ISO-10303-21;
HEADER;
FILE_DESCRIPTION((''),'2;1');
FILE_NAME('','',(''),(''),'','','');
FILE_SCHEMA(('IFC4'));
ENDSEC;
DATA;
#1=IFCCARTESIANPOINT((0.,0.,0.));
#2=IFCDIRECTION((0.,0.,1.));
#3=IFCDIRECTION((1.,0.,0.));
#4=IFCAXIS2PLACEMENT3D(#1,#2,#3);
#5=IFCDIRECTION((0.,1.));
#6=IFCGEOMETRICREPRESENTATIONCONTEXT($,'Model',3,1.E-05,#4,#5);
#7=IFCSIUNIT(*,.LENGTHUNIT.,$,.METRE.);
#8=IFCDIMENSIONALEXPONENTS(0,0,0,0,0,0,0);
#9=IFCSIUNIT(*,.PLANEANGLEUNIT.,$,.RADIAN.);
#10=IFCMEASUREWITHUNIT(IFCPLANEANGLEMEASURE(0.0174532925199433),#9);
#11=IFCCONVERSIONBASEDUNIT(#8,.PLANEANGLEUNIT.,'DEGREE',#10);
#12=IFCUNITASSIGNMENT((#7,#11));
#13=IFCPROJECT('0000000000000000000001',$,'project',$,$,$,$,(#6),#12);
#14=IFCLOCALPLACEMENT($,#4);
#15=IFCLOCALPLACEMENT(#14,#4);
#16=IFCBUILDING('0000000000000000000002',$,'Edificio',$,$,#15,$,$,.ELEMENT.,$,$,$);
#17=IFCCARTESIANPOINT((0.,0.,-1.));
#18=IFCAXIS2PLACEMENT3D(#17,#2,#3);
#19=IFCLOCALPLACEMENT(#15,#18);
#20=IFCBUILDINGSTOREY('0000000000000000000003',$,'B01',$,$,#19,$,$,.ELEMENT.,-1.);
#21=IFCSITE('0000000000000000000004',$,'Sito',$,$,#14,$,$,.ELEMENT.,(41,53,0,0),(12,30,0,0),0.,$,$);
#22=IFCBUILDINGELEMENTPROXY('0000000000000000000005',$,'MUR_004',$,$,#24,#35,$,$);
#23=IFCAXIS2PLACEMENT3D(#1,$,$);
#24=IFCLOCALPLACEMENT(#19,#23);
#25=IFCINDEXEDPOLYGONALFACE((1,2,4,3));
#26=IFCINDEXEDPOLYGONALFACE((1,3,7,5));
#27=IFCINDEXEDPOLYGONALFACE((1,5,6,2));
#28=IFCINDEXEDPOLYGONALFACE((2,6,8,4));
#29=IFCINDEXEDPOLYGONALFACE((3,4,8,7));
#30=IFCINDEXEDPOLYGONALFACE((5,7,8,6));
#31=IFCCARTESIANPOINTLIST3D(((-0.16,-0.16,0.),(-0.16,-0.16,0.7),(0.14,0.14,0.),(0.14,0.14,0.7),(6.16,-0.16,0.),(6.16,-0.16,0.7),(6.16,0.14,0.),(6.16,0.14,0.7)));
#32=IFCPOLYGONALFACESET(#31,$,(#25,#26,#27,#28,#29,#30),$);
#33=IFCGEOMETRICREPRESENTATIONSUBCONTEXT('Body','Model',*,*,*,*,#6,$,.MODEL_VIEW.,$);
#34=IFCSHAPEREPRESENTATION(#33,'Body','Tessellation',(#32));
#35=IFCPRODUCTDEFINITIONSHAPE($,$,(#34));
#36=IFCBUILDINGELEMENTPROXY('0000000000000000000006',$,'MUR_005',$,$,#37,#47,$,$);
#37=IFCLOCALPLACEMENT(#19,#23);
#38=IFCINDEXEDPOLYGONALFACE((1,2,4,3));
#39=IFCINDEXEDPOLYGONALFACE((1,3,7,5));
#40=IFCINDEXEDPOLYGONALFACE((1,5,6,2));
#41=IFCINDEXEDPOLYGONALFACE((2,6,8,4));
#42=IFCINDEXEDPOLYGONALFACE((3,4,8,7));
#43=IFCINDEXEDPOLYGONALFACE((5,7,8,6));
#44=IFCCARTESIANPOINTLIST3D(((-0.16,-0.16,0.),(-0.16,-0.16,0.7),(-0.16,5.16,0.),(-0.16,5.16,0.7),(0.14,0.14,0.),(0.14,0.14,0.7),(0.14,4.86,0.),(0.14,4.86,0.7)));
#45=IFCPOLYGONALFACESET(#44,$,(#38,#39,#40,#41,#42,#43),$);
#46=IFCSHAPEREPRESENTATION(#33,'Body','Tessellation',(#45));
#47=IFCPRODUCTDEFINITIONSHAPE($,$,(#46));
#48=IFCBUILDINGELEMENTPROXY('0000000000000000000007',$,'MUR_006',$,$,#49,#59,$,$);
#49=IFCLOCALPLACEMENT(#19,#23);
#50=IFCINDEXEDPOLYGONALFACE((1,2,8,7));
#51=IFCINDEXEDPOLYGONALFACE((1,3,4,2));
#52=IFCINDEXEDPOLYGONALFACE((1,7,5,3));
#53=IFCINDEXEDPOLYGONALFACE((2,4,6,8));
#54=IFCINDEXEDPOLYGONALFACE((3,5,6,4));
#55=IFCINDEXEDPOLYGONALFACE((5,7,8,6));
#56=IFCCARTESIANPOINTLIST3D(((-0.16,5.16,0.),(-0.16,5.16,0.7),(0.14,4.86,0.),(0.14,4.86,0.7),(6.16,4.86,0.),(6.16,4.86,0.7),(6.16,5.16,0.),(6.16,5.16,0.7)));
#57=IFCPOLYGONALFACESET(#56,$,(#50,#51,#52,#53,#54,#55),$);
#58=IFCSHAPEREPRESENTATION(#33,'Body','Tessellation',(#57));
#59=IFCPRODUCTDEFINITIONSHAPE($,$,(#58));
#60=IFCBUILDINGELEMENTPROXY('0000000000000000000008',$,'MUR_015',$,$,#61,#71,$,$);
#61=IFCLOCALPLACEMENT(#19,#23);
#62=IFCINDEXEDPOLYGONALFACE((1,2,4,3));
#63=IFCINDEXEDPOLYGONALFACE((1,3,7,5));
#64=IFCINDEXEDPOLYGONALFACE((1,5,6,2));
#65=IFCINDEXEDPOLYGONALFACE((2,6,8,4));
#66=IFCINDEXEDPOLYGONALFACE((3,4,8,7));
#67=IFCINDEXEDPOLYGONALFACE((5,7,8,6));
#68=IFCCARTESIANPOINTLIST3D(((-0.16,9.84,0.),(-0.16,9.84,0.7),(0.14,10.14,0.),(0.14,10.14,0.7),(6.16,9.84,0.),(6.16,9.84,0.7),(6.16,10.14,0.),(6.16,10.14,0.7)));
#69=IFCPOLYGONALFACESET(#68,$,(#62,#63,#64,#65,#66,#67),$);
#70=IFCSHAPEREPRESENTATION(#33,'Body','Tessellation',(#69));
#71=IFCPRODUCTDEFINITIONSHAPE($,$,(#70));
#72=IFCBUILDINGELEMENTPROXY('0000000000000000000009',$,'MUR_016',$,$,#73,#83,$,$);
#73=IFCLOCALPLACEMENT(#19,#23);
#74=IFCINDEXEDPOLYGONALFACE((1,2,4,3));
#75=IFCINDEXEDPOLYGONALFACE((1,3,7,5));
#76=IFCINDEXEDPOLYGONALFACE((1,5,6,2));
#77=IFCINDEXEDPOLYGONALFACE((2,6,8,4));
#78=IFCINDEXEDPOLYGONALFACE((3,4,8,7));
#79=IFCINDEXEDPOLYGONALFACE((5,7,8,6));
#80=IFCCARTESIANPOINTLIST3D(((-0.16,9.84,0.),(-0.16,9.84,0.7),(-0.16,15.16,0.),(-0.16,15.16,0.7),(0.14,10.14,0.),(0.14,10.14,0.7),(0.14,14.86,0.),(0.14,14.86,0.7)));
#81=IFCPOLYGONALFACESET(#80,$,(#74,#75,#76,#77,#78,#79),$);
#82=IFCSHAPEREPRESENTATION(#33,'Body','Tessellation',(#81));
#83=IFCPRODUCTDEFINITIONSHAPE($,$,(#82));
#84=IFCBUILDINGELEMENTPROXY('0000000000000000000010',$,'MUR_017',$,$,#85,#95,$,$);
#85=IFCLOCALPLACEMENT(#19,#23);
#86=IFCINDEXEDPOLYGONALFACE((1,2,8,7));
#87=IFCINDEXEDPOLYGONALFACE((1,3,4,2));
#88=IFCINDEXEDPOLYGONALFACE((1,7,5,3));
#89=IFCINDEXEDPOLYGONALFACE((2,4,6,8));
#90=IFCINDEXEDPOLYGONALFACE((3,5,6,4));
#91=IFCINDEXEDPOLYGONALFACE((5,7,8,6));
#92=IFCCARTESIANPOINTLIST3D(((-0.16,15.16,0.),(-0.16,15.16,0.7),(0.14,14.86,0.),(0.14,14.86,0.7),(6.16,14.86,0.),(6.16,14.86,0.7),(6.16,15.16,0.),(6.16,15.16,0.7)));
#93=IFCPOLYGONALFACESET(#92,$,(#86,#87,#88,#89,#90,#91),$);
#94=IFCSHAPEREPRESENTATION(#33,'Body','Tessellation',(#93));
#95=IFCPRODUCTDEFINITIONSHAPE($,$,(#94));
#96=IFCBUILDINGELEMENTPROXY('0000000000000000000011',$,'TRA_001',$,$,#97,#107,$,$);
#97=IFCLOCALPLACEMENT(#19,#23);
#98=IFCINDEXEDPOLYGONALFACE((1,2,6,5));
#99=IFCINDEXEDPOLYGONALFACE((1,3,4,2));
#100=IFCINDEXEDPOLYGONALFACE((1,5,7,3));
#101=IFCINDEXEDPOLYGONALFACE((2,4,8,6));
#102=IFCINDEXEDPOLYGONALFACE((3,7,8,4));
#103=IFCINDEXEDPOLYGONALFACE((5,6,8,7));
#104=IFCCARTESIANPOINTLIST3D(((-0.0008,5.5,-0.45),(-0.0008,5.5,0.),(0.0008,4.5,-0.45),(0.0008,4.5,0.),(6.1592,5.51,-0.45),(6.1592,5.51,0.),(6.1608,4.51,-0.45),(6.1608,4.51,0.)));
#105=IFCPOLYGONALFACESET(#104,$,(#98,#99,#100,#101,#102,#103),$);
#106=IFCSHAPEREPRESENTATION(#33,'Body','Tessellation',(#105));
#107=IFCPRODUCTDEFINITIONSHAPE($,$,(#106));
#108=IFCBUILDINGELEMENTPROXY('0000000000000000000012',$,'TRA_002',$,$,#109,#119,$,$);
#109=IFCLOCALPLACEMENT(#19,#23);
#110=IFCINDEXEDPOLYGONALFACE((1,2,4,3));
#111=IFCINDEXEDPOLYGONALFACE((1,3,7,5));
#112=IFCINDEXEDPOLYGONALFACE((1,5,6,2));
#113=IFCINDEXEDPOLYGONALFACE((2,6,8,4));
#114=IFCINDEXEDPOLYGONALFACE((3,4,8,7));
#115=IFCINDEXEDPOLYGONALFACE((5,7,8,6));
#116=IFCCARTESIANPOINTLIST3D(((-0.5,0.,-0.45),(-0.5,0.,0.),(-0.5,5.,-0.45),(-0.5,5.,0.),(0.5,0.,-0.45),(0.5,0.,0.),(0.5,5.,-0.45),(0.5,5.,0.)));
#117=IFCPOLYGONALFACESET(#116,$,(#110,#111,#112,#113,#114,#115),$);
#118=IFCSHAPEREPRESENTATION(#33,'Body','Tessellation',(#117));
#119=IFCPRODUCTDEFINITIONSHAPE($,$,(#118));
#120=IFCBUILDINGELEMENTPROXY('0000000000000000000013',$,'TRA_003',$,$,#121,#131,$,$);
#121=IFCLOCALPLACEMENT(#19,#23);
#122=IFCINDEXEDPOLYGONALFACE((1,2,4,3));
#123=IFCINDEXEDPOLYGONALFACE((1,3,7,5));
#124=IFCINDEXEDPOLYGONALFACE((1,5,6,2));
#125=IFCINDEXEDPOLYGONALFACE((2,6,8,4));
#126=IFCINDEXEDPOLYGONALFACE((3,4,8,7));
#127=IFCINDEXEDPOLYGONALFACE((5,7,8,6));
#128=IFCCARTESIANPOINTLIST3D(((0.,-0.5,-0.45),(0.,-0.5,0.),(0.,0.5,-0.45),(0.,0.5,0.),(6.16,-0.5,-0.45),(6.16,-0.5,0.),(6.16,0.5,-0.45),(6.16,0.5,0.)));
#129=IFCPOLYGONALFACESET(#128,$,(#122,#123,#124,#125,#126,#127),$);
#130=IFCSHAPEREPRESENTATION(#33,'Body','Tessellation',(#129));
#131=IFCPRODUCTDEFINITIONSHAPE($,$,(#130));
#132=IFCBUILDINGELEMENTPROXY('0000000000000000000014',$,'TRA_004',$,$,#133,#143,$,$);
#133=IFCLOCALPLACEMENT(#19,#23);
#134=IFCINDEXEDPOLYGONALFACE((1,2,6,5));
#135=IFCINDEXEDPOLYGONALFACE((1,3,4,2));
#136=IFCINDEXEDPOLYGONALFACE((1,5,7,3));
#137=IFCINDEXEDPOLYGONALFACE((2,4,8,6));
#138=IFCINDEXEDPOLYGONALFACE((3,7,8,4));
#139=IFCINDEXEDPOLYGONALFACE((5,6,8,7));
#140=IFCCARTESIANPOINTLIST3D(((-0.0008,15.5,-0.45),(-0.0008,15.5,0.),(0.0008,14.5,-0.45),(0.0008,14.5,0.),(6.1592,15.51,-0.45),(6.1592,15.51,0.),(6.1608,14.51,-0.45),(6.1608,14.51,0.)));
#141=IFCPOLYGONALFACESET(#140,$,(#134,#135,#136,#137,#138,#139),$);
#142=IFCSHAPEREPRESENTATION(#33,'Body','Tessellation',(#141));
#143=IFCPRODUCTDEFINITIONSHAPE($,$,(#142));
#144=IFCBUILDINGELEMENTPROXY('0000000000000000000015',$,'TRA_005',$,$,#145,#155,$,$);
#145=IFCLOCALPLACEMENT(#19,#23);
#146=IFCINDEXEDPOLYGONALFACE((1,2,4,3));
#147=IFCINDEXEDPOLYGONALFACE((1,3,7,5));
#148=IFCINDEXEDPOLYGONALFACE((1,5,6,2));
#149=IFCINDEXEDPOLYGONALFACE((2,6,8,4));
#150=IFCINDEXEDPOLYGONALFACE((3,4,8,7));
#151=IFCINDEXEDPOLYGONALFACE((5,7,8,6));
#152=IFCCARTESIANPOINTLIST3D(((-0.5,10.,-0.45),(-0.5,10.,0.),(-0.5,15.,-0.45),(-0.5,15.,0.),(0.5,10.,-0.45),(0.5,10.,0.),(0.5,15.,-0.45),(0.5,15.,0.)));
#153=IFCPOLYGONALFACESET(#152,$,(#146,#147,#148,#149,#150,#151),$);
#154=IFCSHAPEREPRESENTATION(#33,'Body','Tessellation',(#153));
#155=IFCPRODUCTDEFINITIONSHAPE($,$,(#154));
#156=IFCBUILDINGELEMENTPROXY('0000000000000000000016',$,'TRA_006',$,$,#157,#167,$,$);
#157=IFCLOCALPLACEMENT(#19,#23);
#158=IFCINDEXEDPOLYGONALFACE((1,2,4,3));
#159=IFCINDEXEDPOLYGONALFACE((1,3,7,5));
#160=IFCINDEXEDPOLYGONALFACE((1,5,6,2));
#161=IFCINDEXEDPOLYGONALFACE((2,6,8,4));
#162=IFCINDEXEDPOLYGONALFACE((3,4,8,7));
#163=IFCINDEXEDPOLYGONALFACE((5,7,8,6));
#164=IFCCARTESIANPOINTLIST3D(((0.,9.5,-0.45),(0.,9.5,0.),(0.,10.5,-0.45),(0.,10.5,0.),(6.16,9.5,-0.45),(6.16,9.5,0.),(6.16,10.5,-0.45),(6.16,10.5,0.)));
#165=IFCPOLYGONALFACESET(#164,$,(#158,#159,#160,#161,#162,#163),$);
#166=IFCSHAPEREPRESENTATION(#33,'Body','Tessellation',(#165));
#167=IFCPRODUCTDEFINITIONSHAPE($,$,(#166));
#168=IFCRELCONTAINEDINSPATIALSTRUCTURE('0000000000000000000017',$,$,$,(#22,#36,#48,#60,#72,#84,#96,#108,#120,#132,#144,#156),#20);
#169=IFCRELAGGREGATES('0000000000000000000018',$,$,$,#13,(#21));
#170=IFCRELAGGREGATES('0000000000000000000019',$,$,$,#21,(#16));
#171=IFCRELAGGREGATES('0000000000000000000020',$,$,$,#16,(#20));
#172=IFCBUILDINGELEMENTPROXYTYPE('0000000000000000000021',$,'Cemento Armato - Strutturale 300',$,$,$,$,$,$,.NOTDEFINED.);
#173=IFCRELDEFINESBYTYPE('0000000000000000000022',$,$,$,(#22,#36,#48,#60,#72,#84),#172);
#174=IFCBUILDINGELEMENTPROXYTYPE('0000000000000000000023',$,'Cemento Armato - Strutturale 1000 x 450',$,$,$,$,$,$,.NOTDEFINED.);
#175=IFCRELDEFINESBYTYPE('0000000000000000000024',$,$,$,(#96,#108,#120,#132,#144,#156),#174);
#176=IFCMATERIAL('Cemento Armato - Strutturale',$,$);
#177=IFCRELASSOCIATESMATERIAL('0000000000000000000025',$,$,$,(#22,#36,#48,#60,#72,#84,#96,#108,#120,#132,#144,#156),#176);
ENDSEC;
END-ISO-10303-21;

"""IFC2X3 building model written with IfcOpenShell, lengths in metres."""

from ifc_helpers import new_model, entity, si_unit, converted_unit, direction, frame, frame_2d, origin_with_axes, place, context, subcontext, project, spatial, polyline, rectangle, outline, extrude, material, type_object, element, save


model = new_model("IFC2X3")

# Units and contexts
model_context = context("Model", 3, precision=1e-05, world=origin_with_axes(), true_north=direction((0.0, 1.0)))
body_context = subcontext(model_context, "Body", "Model", "MODEL_VIEW")
ifc_project = project(units=[si_unit("LENGTHUNIT", "METRE"), converted_unit("PLANEANGLEUNIT", "DEGREE", entity("IfcPlaneAngleMeasure", 0.0174532925199433), si_unit("PLANEANGLEUNIT", "RADIAN"), dimensions=[0, 0, 0, 0, 0, 0, 0])], contexts=[model_context])

# Site, building, storey
site_placement = place(None, origin_with_axes())
site = spatial("IfcSite", under=ifc_project, at=site_placement, Name="Sito", CompositionType="ELEMENT", RefLatitude=(41, 53, 0, 0), RefLongitude=(12, 30, 0, 0), RefElevation=0.0)
building_placement = place(site_placement, origin_with_axes())
building = spatial("IfcBuilding", under=site, at=building_placement, Name="Edificio", CompositionType="ELEMENT")
storey_placement = place(building_placement, frame((0.0, 0.0, -1.0), z_axis=(0.0, 0.0, 1.0), x_axis=(1.0, 0.0, 0.0)))
storey = spatial("IfcBuildingStorey", under=building, at=storey_placement, Name="B01", CompositionType="ELEMENT", Elevation=-1.0)

# Building element proxies
ifc_material = material(Name="Cemento Armato - Strutturale")
building_element_proxy_type_1 = type_object("IfcBuildingElementProxyType", Name="Cemento Armato - Strutturale 300", PredefinedType="NOTDEFINED")
proxy_1_placement = place(storey_placement, frame((-0.16, -0.16, 0.0), z_axis=(0.0, 0.0, 1.0), x_axis=(1.0, 0.0, 0.0)))
element("IfcBuildingElementProxy", 1, at=proxy_1_placement, inside=storey, type_object=building_element_proxy_type_1, material=ifc_material, Name="MUR_004", context=body_context, shape_type="SweptSolid", body=[
    extrude(outline(polyline([(0.0, 0.0), (6.32, 0.0), (6.32, 0.3), (0.3, 0.3), (0.0, 0.0)])), origin_with_axes(), (0.0, 0.0, 1.0), 0.7),
])
proxy_2_placement = place(storey_placement, frame((-0.16, 5.16, 0.0), z_axis=(0.0, 0.0, 1.0), x_axis=(0.0, -1.0, 0.0)))
element("IfcBuildingElementProxy", 2, at=proxy_2_placement, inside=storey, type_object=building_element_proxy_type_1, material=ifc_material, Name="MUR_005", context=body_context, shape_type="SweptSolid", body=[
    extrude(outline(polyline([(0.0, 0.0), (5.32, 0.0), (5.02, 0.3), (0.3, 0.3), (0.0, 0.0)])), origin_with_axes(), (0.0, 0.0, 1.0), 0.7),
])
proxy_3_placement = place(storey_placement, frame((6.16, 5.16, 0.0), z_axis=(0.0, 0.0, 1.0), x_axis=(-1.0, 0.0, 0.0)))
element("IfcBuildingElementProxy", 3, at=proxy_3_placement, inside=storey, type_object=building_element_proxy_type_1, material=ifc_material, Name="MUR_006", context=body_context, shape_type="SweptSolid", body=[
    extrude(outline(polyline([(0.0, 0.0), (6.32, 0.0), (6.02, 0.3), (0.0, 0.3), (0.0, 0.0)])), origin_with_axes(), (0.0, 0.0, 1.0), 0.7),
])
proxy_4_placement = place(storey_placement, frame((-0.16, 9.84, 0.0), z_axis=(0.0, 0.0, 1.0), x_axis=(1.0, 0.0, 0.0)))
element("IfcBuildingElementProxy", 4, at=proxy_4_placement, inside=storey, type_object=building_element_proxy_type_1, material=ifc_material, Name="MUR_015", context=body_context, shape_type="SweptSolid", body=[
    extrude(outline(polyline([(0.0, 0.0), (6.32, 0.0), (6.32, 0.3), (0.3, 0.3), (0.0, 0.0)])), origin_with_axes(), (0.0, 0.0, 1.0), 0.7),
])
proxy_5_placement = place(storey_placement, frame((-0.16, 15.16, 0.0), z_axis=(0.0, 0.0, 1.0), x_axis=(0.0, -1.0, 0.0)))
element("IfcBuildingElementProxy", 5, at=proxy_5_placement, inside=storey, type_object=building_element_proxy_type_1, material=ifc_material, Name="MUR_016", context=body_context, shape_type="SweptSolid", body=[
    extrude(outline(polyline([(0.0, 0.0), (5.32, 0.0), (5.02, 0.3), (0.3, 0.3), (0.0, 0.0)])), origin_with_axes(), (0.0, 0.0, 1.0), 0.7),
])
proxy_6_placement = place(storey_placement, frame((6.16, 15.16, 0.0), z_axis=(0.0, 0.0, 1.0), x_axis=(-1.0, 0.0, 0.0)))
element("IfcBuildingElementProxy", 6, at=proxy_6_placement, inside=storey, type_object=building_element_proxy_type_1, material=ifc_material, Name="MUR_017", context=body_context, shape_type="SweptSolid", body=[
    extrude(outline(polyline([(0.0, 0.0), (6.32, 0.0), (6.02, 0.3), (0.0, 0.3), (0.0, 0.0)])), origin_with_axes(), (0.0, 0.0, 1.0), 0.7),
])
building_element_proxy_type_2 = type_object("IfcBuildingElementProxyType", Name="Cemento Armato - Strutturale 1000 x 450", PredefinedType="NOTDEFINED")
proxy_7_placement = place(storey_placement, frame((6.16, 5.01, 0.0), z_axis=(0.0, 0.0, 1.0), x_axis=(-0.001623, 0.999999, 0.0)))
element("IfcBuildingElementProxy", 7, at=proxy_7_placement, inside=storey, type_object=building_element_proxy_type_2, material=ifc_material, Name="TRA_001", context=body_context, shape_type="SweptSolid", body=[
    extrude(rectangle(XDim=0.45, YDim=1.0, at=frame_2d((-0.225, 0.0), x_axis=(1.0, 0.0))), frame((0.0, 0.0, 0.0), z_axis=(0.0, 1.0, 0.0), x_axis=(0.0, 0.0, 1.0)), (0.0, 0.0, 1.0), 6.16),
])
proxy_8_placement = place(storey_placement, frame((0.0, 5.0, 0.0), z_axis=(0.0, 0.0, 1.0), x_axis=(-1.0, 0.0, 0.0)))
element("IfcBuildingElementProxy", 8, at=proxy_8_placement, inside=storey, type_object=building_element_proxy_type_2, material=ifc_material, Name="TRA_002", context=body_context, shape_type="SweptSolid", body=[
    extrude(rectangle(XDim=0.45, YDim=1.0, at=frame_2d((-0.225, 0.0), x_axis=(1.0, 0.0))), frame((0.0, 0.0, 0.0), z_axis=(0.0, 1.0, 0.0), x_axis=(0.0, 0.0, 1.0)), (0.0, 0.0, 1.0), 5.0),
])
proxy_9_placement = place(storey_placement, frame((0.0, 0.0, 0.0), z_axis=(0.0, 0.0, 1.0), x_axis=(0.0, -1.0, 0.0)))
element("IfcBuildingElementProxy", 9, at=proxy_9_placement, inside=storey, type_object=building_element_proxy_type_2, material=ifc_material, Name="TRA_003", context=body_context, shape_type="SweptSolid", body=[
    extrude(rectangle(XDim=0.45, YDim=1.0, at=frame_2d((-0.225, 0.0), x_axis=(1.0, 0.0))), frame((0.0, 0.0, 0.0), z_axis=(0.0, 1.0, 0.0), x_axis=(0.0, 0.0, 1.0)), (0.0, 0.0, 1.0), 6.16),
])
proxy_10_placement = place(storey_placement, frame((6.16, 15.01, 0.0), z_axis=(0.0, 0.0, 1.0), x_axis=(-0.001623, 0.999999, 0.0)))
element("IfcBuildingElementProxy", 10, at=proxy_10_placement, inside=storey, type_object=building_element_proxy_type_2, material=ifc_material, Name="TRA_004", context=body_context, shape_type="SweptSolid", body=[
    extrude(rectangle(XDim=0.45, YDim=1.0, at=frame_2d((-0.225, 0.0), x_axis=(1.0, 0.0))), frame((0.0, 0.0, 0.0), z_axis=(0.0, 1.0, 0.0), x_axis=(0.0, 0.0, 1.0)), (0.0, 0.0, 1.0), 6.16),
])
proxy_11_placement = place(storey_placement, frame((0.0, 15.0, 0.0), z_axis=(0.0, 0.0, 1.0), x_axis=(-1.0, 0.0, 0.0)))
element("IfcBuildingElementProxy", 11, at=proxy_11_placement, inside=storey, type_object=building_element_proxy_type_2, material=ifc_material, Name="TRA_005", context=body_context, shape_type="SweptSolid", body=[
    extrude(rectangle(XDim=0.45, YDim=1.0, at=frame_2d((-0.225, 0.0), x_axis=(1.0, 0.0))), frame((0.0, 0.0, 0.0), z_axis=(0.0, 1.0, 0.0), x_axis=(0.0, 0.0, 1.0)), (0.0, 0.0, 1.0), 5.0),
])
proxy_12_placement = place(storey_placement, frame((0.0, 10.0, 0.0), z_axis=(0.0, 0.0, 1.0), x_axis=(0.0, -1.0, 0.0)))
element("IfcBuildingElementProxy", 12, at=proxy_12_placement, inside=storey, type_object=building_element_proxy_type_2, material=ifc_material, Name="TRA_006", context=body_context, shape_type="SweptSolid", body=[
    extrude(rectangle(XDim=0.45, YDim=1.0, at=frame_2d((-0.225, 0.0), x_axis=(1.0, 0.0))), frame((0.0, 0.0, 0.0), z_axis=(0.0, 1.0, 0.0), x_axis=(0.0, 0.0, 1.0)), (0.0, 0.0, 1.0), 6.16),
])

save(model, "model.ifc")
